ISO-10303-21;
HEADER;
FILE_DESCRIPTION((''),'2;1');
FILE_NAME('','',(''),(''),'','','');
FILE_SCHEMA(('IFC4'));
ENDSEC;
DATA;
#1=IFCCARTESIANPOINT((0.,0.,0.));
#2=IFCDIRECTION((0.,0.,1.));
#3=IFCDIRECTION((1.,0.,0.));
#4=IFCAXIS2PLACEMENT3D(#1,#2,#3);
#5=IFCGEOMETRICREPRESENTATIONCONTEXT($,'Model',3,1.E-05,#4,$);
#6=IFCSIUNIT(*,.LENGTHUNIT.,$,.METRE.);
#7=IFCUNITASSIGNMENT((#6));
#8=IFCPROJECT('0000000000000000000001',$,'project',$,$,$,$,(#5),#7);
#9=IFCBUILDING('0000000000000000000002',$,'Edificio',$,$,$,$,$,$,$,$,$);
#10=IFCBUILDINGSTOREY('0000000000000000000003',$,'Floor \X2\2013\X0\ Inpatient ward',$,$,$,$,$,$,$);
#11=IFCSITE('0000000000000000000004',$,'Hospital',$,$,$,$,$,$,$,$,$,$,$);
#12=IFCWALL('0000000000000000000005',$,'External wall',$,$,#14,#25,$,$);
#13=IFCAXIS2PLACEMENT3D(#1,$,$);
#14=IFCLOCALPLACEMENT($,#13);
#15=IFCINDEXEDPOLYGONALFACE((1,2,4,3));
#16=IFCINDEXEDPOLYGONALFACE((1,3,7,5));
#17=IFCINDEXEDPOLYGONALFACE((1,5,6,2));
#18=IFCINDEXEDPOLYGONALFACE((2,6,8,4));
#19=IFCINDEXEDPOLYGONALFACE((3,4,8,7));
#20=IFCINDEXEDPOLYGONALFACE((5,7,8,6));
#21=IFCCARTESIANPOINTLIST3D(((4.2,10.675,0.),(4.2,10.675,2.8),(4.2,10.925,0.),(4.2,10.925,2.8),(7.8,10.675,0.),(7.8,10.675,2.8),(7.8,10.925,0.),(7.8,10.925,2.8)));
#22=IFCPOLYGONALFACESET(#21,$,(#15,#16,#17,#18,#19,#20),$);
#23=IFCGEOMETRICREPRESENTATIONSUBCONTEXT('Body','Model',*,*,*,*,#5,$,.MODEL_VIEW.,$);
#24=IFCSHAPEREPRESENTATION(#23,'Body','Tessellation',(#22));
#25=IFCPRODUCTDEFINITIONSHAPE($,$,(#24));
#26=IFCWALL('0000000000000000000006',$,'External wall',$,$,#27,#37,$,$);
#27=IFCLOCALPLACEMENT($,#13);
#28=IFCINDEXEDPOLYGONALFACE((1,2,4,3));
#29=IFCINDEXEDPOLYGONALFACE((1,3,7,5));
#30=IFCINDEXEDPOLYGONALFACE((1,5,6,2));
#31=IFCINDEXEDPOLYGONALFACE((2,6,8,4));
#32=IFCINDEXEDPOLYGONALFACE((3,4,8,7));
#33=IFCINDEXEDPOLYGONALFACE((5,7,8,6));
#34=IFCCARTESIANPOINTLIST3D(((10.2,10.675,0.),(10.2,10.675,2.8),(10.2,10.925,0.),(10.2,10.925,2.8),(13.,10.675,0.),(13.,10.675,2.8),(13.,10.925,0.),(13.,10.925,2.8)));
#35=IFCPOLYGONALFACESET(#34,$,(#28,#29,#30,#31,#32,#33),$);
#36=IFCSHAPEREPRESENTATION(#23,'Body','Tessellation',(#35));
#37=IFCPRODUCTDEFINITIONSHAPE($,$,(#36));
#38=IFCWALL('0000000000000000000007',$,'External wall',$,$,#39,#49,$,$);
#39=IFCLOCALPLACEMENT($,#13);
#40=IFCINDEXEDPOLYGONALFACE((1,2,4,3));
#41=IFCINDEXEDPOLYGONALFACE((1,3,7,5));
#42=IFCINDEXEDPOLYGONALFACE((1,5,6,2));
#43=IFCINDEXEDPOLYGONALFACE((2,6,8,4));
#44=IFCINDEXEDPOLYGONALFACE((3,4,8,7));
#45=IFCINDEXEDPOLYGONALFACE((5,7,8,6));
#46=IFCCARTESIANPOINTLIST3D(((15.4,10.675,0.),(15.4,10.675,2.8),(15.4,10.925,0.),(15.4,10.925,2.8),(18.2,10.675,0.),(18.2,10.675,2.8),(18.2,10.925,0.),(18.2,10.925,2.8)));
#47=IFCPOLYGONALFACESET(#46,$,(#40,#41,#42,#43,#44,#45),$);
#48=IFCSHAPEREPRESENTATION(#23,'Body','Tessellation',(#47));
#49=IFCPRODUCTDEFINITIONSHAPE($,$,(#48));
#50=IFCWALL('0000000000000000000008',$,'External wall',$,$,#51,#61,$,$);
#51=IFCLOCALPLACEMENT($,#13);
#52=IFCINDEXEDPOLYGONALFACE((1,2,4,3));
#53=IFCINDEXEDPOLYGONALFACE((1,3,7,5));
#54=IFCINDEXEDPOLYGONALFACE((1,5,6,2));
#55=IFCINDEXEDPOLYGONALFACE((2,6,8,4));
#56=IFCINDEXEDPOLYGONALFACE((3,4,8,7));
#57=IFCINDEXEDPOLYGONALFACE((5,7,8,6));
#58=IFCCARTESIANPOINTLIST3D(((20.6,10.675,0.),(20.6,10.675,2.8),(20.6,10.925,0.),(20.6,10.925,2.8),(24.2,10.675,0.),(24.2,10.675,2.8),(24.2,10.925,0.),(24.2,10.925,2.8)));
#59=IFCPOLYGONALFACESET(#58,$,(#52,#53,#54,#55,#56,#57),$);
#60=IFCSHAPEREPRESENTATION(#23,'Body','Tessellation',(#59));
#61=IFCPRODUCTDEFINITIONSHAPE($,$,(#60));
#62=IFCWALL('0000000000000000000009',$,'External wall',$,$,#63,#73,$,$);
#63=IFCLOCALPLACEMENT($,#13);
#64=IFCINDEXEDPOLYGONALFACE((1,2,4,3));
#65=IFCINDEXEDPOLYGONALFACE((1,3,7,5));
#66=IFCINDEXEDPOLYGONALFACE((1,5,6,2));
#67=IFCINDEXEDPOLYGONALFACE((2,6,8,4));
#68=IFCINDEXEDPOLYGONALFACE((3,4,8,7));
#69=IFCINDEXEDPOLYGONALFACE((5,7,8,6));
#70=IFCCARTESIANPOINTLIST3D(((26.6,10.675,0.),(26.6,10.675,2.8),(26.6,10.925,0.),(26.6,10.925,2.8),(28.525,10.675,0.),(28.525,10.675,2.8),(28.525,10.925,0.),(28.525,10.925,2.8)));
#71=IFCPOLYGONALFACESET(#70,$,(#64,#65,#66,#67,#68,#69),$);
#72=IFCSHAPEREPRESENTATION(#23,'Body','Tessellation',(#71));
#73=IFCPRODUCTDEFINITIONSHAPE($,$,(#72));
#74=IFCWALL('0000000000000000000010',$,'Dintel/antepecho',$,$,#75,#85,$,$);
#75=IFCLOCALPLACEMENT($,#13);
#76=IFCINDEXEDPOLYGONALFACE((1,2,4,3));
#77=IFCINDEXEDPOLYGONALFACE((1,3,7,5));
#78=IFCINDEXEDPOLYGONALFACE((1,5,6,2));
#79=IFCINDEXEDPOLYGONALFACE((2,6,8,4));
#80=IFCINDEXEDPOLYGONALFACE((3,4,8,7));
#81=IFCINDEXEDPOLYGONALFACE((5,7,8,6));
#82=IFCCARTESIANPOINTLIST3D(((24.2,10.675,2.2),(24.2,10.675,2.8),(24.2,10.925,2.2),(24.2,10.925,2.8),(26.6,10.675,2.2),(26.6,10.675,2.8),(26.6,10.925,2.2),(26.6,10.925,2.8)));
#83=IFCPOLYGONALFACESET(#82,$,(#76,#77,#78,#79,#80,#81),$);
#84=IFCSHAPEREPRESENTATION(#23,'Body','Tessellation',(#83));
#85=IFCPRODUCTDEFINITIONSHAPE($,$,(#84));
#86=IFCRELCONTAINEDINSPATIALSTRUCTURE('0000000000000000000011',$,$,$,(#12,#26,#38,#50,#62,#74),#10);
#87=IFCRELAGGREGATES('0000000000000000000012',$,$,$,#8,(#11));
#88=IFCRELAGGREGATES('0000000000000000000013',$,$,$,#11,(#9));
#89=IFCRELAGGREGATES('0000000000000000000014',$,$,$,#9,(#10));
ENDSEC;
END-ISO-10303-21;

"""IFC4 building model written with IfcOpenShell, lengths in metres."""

from ifc_helpers import new_model, si_unit, frame, origin_with_axes, context, subcontext, project, spatial, line, indexed_curve, outline, extrude, element, save


model = new_model("IFC4")

# Units and contexts
model_context = context("Model", 3, precision=1e-05, world=origin_with_axes())
body_context = subcontext(model_context, "Body", "Model", "MODEL_VIEW")
ifc_project = project(units=[si_unit("LENGTHUNIT", "METRE")], contexts=[model_context])

# Site, building, storey
site = spatial("IfcSite", under=ifc_project, Name="Hospital")
building = spatial("IfcBuilding", under=site, Name="Edificio")
storey = spatial("IfcBuildingStorey", under=building, Name="Floor – Inpatient ward")

# Walls
element("IfcWall", 1, inside=storey, Name="External wall", context=body_context, shape_type="SweptSolid", body=[
    extrude(outline(indexed_curve([(0.0, 0.0), (3.6, 0.0), (3.6, 0.25), (0.0, 0.25)], segments=[line(1, 2, 3, 4, 1)])), frame((4.2, 10.675, 0.0), z_axis=(0.0, 0.0, 1.0), x_axis=(1.0, 0.0, 0.0)), (0.0, 0.0, 1.0), 2.8),
])
element("IfcWall", 2, inside=storey, Name="External wall", context=body_context, shape_type="SweptSolid", body=[
    extrude(outline(indexed_curve([(0.0, 0.0), (2.8, 0.0), (2.8, 0.25), (0.0, 0.25)], segments=[line(1, 2, 3, 4, 1)])), frame((10.2, 10.675, 0.0), z_axis=(0.0, 0.0, 1.0), x_axis=(1.0, 0.0, 0.0)), (0.0, 0.0, 1.0), 2.8),
])
element("IfcWall", 3, inside=storey, Name="External wall", context=body_context, shape_type="SweptSolid", body=[
    extrude(outline(indexed_curve([(0.0, 0.0), (2.8, 0.0), (2.8, 0.25), (0.0, 0.25)], segments=[line(1, 2, 3, 4, 1)])), frame((15.4, 10.675, 0.0), z_axis=(0.0, 0.0, 1.0), x_axis=(1.0, 0.0, 0.0)), (0.0, 0.0, 1.0), 2.8),
])
element("IfcWall", 4, inside=storey, Name="External wall", context=body_context, shape_type="SweptSolid", body=[
    extrude(outline(indexed_curve([(0.0, 0.0), (3.6, 0.0), (3.6, 0.25), (0.0, 0.25)], segments=[line(1, 2, 3, 4, 1)])), frame((20.6, 10.675, 0.0), z_axis=(0.0, 0.0, 1.0), x_axis=(1.0, 0.0, 0.0)), (0.0, 0.0, 1.0), 2.8),
])
element("IfcWall", 5, inside=storey, Name="External wall", context=body_context, shape_type="SweptSolid", body=[
    extrude(outline(indexed_curve([(0.0, 0.0), (1.925, 0.0), (1.925, 0.25), (0.0, 0.25)], segments=[line(1, 2, 3, 4, 1)])), frame((26.6, 10.675, 0.0), z_axis=(0.0, 0.0, 1.0), x_axis=(1.0, 0.0, 0.0)), (0.0, 0.0, 1.0), 2.8),
])
element("IfcWall", 6, inside=storey, Name="Dintel/antepecho", context=body_context, shape_type="SweptSolid", body=[
    extrude(outline(indexed_curve([(0.0, 0.0), (2.4, 0.0), (2.4, 0.25), (0.0, 0.25)], segments=[line(1, 2, 3, 4, 1)])), frame((24.2, 10.675, 2.2), z_axis=(0.0, 0.0, 1.0), x_axis=(1.0, 0.0, 0.0)), (0.0, 0.0, 1.0), 0.6),
])

save(model, "model.ifc")
